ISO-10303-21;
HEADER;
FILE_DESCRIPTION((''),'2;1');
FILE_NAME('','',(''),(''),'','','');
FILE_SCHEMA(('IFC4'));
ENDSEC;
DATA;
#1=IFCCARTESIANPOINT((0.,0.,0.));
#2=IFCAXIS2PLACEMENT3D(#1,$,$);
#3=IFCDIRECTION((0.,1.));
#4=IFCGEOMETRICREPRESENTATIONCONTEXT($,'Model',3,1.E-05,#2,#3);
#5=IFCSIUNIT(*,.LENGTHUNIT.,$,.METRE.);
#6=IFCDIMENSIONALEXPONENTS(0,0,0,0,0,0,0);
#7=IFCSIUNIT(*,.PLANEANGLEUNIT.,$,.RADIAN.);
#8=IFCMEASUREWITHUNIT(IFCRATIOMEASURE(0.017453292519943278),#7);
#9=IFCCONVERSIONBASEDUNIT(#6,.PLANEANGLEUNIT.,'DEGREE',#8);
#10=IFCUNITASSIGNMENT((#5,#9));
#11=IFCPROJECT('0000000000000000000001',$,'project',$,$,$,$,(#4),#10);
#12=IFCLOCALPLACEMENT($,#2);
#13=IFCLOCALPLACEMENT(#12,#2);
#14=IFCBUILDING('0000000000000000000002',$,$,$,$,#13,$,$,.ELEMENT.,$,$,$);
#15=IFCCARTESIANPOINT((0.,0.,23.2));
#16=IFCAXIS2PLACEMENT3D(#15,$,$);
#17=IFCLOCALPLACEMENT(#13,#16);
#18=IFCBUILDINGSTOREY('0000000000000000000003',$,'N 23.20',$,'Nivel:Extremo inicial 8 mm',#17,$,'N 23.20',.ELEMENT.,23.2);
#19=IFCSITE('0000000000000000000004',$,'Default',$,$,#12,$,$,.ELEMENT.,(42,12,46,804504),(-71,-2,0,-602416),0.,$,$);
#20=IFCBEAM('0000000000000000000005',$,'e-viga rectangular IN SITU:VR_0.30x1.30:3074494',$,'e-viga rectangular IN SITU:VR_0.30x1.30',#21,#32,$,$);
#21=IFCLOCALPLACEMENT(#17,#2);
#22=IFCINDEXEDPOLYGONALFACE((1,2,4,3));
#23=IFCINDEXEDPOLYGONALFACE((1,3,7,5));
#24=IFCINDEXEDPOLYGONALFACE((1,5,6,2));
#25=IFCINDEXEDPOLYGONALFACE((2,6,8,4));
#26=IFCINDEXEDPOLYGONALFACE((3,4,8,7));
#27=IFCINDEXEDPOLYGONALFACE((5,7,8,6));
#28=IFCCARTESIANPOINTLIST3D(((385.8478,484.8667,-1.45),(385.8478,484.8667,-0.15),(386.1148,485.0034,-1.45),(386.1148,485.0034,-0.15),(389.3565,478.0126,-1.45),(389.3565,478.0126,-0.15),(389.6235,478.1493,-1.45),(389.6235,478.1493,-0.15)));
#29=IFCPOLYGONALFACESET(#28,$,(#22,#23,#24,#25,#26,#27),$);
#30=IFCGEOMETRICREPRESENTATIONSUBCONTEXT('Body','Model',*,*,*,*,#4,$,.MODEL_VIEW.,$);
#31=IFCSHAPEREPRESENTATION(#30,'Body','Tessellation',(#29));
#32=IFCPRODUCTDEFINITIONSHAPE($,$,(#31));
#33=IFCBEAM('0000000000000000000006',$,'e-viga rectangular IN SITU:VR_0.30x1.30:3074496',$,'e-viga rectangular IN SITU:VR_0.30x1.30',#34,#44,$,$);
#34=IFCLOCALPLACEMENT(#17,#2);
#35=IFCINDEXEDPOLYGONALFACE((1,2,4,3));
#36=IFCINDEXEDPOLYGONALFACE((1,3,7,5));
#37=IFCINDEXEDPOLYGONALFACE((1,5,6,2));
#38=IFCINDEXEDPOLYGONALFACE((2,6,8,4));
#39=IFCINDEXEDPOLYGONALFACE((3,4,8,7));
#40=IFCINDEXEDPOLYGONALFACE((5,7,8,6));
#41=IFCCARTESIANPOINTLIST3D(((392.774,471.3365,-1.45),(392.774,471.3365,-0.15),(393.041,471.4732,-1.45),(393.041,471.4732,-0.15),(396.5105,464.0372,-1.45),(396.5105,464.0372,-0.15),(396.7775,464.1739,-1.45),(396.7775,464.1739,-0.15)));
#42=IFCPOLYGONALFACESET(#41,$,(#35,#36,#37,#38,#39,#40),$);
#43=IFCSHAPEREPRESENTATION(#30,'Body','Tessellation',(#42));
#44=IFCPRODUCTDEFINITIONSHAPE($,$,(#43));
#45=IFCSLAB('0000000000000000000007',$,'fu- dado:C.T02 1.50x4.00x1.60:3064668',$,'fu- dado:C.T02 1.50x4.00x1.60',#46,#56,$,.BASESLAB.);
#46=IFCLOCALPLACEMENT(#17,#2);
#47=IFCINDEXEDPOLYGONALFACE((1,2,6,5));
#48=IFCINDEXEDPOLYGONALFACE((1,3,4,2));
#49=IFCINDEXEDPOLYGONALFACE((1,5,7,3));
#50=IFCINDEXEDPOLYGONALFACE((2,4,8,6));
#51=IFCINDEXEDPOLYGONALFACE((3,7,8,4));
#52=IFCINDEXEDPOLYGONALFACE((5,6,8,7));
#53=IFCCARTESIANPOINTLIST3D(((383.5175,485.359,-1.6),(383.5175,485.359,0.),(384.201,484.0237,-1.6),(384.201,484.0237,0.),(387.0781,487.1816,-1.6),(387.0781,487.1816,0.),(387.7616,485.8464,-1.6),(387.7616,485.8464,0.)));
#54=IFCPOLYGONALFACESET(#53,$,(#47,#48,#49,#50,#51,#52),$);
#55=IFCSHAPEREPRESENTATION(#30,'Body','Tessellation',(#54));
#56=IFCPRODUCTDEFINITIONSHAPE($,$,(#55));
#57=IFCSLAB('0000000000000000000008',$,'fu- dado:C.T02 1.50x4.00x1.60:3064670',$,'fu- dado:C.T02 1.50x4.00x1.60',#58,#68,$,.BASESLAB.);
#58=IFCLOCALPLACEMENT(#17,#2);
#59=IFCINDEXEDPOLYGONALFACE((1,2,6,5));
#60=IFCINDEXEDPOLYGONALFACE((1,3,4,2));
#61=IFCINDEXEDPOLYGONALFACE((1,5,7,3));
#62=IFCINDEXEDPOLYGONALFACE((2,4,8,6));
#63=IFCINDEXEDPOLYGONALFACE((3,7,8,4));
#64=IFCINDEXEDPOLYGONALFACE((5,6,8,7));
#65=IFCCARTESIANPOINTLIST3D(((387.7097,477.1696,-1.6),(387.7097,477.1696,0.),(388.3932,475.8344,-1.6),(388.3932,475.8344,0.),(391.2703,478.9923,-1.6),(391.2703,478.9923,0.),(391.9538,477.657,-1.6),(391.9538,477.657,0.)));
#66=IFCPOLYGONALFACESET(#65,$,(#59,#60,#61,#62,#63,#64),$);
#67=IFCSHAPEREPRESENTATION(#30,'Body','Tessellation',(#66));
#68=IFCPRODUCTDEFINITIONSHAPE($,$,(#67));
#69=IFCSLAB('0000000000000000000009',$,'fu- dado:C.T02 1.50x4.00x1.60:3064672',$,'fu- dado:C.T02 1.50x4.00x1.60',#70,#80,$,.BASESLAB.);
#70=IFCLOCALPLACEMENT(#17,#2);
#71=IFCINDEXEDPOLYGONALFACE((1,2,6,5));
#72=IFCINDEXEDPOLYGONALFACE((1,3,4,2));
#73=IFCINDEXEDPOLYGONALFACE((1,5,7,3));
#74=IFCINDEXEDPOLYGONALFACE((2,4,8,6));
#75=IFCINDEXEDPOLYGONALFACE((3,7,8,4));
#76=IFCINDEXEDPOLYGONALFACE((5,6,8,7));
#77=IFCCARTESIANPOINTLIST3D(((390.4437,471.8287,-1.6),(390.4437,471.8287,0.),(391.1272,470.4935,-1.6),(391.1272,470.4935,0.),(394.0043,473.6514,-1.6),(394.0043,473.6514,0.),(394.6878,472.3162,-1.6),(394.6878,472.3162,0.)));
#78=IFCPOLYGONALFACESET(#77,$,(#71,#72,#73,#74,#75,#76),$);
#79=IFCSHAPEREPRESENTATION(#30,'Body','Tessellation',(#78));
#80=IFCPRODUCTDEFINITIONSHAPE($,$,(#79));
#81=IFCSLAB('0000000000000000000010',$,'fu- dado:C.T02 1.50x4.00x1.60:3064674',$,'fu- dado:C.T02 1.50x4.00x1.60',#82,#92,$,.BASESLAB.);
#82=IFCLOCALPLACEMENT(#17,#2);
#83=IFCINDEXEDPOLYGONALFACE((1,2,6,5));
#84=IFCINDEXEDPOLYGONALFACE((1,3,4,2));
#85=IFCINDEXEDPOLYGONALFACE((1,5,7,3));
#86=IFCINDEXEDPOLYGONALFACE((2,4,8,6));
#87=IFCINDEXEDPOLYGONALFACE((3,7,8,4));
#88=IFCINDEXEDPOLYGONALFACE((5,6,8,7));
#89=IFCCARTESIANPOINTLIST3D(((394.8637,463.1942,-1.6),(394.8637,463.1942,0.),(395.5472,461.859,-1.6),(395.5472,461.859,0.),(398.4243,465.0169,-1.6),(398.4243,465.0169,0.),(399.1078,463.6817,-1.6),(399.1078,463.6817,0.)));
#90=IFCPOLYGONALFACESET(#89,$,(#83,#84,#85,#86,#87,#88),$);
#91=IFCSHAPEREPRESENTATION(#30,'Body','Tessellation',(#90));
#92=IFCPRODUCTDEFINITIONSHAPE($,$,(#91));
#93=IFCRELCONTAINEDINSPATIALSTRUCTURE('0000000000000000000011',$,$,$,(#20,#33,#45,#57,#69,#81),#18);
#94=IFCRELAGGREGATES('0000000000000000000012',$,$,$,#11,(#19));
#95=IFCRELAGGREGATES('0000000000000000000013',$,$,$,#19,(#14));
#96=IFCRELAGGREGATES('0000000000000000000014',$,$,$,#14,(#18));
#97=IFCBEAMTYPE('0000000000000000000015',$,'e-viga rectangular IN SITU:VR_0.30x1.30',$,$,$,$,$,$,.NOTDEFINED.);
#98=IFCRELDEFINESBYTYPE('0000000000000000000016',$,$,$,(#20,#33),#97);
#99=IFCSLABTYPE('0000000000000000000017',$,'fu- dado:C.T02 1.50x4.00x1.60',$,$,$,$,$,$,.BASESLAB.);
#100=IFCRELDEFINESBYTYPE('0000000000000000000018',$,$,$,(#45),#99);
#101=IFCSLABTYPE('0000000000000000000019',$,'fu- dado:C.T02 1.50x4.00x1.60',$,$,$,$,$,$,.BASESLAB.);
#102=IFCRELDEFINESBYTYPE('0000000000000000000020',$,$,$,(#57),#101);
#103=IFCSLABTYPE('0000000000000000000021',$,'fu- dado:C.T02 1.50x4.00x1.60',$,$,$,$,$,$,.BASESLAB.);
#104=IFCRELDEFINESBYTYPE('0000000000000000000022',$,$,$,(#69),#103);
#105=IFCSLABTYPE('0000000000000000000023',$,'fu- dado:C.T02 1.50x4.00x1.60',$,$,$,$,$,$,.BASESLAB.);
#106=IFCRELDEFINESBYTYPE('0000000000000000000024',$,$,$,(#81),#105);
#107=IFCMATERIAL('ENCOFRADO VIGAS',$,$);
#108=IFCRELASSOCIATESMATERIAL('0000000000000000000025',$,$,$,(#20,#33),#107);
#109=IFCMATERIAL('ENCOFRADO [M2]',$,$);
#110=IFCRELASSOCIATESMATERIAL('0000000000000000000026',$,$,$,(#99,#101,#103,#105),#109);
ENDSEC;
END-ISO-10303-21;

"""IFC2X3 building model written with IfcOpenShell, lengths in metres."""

from ifc_helpers import new_model, entity, si_unit, converted_unit, direction, frame, frame_2d, origin, origin_2d_with_axis, place, context, subcontext, project, spatial, rectangle, extrude, material, type_object, element, save


model = new_model("IFC2X3")

# Units and contexts
model_context = context("Model", 3, precision=1e-05, world=origin(), true_north=direction((0.0, 1.0)))
body_context = subcontext(model_context, "Body", "Model", "MODEL_VIEW")
ifc_project = project(units=[si_unit("LENGTHUNIT", "METRE"), converted_unit("PLANEANGLEUNIT", "DEGREE", entity("IfcRatioMeasure", 0.017453292519943278), si_unit("PLANEANGLEUNIT", "RADIAN"), dimensions=[0, 0, 0, 0, 0, 0, 0])], contexts=[model_context])

# Site, building, storey
site_placement = place(None, origin())
site = spatial("IfcSite", under=ifc_project, at=site_placement, Name="Default", CompositionType="ELEMENT", RefLatitude=(42, 12, 46, 804504), RefLongitude=(-71, -2, 0, -602416), RefElevation=0.0)
building_placement = place(site_placement, origin())
building = spatial("IfcBuilding", under=site, at=building_placement, CompositionType="ELEMENT")
storey_placement = place(building_placement, frame((0.0, 0.0, 23.2)))
storey = spatial("IfcBuildingStorey", under=building, at=storey_placement, Name="N 23.20", ObjectType="Nivel:Extremo inicial 8 mm", LongName="N 23.20", CompositionType="ELEMENT", Elevation=23.2)

# Shared definitions
ifc_material_1 = material(Name="ENCOFRADO [M2]")

# Beams
ifc_material_2 = material(Name="ENCOFRADO VIGAS")
beam_type = type_object("IfcBeamType", Name="e-viga rectangular IN SITU:VR_0.30x1.30", PredefinedType="NOTDEFINED")
beam_1_placement = place(storey_placement, frame((385.9813, 484.9351, 0.0), z_axis=(0.0, 0.0, 1.0), x_axis=(0.45567, -0.890149, 0.0)))
element("IfcBeam", 1, at=beam_1_placement, inside=storey, type_object=beam_type, material=ifc_material_2, Name="e-viga rectangular IN SITU:VR_0.30x1.30:3074494", ObjectType="e-viga rectangular IN SITU:VR_0.30x1.30", context=body_context, shape_type="SweptSolid", body=[
    extrude(rectangle(XDim=1.3, YDim=0.3, at=frame_2d((0.0, 0.0), x_axis=(1.0, 0.0))), frame((0.0, 0.0, -0.8), z_axis=(1.0, 0.0, 0.0), x_axis=(0.0, 0.0, -1.0)), (0.0, 0.0, 1.0), 7.7),
])
beam_2_placement = place(storey_placement, frame((392.9075, 471.4048, 0.0), z_axis=(0.0, 0.0, 1.0), x_axis=(0.45567, -0.890149, 0.0)))
element("IfcBeam", 2, at=beam_2_placement, inside=storey, type_object=beam_type, material=ifc_material_2, Name="e-viga rectangular IN SITU:VR_0.30x1.30:3074496", ObjectType="e-viga rectangular IN SITU:VR_0.30x1.30", context=body_context, shape_type="SweptSolid", body=[
    extrude(rectangle(XDim=1.3, YDim=0.3, at=frame_2d((0.0, 0.0), x_axis=(1.0, 0.0))), frame((0.0, 0.0, -0.8), z_axis=(1.0, 0.0, 0.0), x_axis=(0.0, 0.0, -1.0)), (0.0, 0.0, 1.0), 8.2),
])

# Slabs
slab_type_1 = type_object("IfcSlabType", Name="fu- dado:C.T02 1.50x4.00x1.60", PredefinedType="BASESLAB", material=ifc_material_1)
slab_1_placement = place(storey_placement, origin())
element("IfcSlab", 3, at=slab_1_placement, inside=storey, type_object=slab_type_1, Name="fu- dado:C.T02 1.50x4.00x1.60:3064668", ObjectType="fu- dado:C.T02 1.50x4.00x1.60", PredefinedType="BASESLAB", context=body_context, shape_type="SweptSolid", body=[
    extrude(rectangle(XDim=4.0, YDim=1.5, at=frame_2d((0.0, 0.0), x_axis=(1.0, 0.0))), frame((385.6396, 485.6027, -1.6), z_axis=(0.0, 0.0, 1.0), x_axis=(-0.890149, -0.45567, 0.0)), (0.0, 0.0, 1.0), 1.6),
])
slab_type_2 = type_object("IfcSlabType", Name="fu- dado:C.T02 1.50x4.00x1.60", PredefinedType="BASESLAB", material=ifc_material_1)
slab_2_placement = place(storey_placement, origin())
element("IfcSlab", 4, at=slab_2_placement, inside=storey, type_object=slab_type_2, Name="fu- dado:C.T02 1.50x4.00x1.60:3064670", ObjectType="fu- dado:C.T02 1.50x4.00x1.60", PredefinedType="BASESLAB", context=body_context, shape_type="SweptSolid", body=[
    extrude(rectangle(XDim=4.0, YDim=1.5, at=frame_2d((0.0, 0.0), x_axis=(1.0, 0.0))), frame((389.8317, 477.4133, -1.6), z_axis=(0.0, 0.0, 1.0), x_axis=(-0.890149, -0.45567, 0.0)), (0.0, 0.0, 1.0), 1.6),
])
slab_type_3 = type_object("IfcSlabType", Name="fu- dado:C.T02 1.50x4.00x1.60", PredefinedType="BASESLAB", material=ifc_material_1)
slab_3_placement = place(storey_placement, origin())
element("IfcSlab", 5, at=slab_3_placement, inside=storey, type_object=slab_type_3, Name="fu- dado:C.T02 1.50x4.00x1.60:3064672", ObjectType="fu- dado:C.T02 1.50x4.00x1.60", PredefinedType="BASESLAB", context=body_context, shape_type="SweptSolid", body=[
    extrude(rectangle(XDim=4.0, YDim=1.5, at=frame_2d((0.0, 0.0), x_axis=(1.0, 0.0))), frame((392.5658, 472.0724, -1.6), z_axis=(0.0, 0.0, 1.0), x_axis=(-0.890149, -0.45567, 0.0)), (0.0, 0.0, 1.0), 1.6),
])
slab_type_4 = type_object("IfcSlabType", Name="fu- dado:C.T02 1.50x4.00x1.60", PredefinedType="BASESLAB", material=ifc_material_1)
slab_4_placement = place(storey_placement, origin())
element("IfcSlab", 6, at=slab_4_placement, inside=storey, type_object=slab_type_4, Name="fu- dado:C.T02 1.50x4.00x1.60:3064674", ObjectType="fu- dado:C.T02 1.50x4.00x1.60", PredefinedType="BASESLAB", context=body_context, shape_type="SweptSolid", body=[
    extrude(rectangle(XDim=4.0, YDim=1.5, at=origin_2d_with_axis()), frame((396.9858, 463.438, -1.6), z_axis=(0.0, 0.0, 1.0), x_axis=(-0.890149, -0.45567, 0.0)), (0.0, 0.0, 1.0), 1.6),
])

save(model, "model.ifc")
